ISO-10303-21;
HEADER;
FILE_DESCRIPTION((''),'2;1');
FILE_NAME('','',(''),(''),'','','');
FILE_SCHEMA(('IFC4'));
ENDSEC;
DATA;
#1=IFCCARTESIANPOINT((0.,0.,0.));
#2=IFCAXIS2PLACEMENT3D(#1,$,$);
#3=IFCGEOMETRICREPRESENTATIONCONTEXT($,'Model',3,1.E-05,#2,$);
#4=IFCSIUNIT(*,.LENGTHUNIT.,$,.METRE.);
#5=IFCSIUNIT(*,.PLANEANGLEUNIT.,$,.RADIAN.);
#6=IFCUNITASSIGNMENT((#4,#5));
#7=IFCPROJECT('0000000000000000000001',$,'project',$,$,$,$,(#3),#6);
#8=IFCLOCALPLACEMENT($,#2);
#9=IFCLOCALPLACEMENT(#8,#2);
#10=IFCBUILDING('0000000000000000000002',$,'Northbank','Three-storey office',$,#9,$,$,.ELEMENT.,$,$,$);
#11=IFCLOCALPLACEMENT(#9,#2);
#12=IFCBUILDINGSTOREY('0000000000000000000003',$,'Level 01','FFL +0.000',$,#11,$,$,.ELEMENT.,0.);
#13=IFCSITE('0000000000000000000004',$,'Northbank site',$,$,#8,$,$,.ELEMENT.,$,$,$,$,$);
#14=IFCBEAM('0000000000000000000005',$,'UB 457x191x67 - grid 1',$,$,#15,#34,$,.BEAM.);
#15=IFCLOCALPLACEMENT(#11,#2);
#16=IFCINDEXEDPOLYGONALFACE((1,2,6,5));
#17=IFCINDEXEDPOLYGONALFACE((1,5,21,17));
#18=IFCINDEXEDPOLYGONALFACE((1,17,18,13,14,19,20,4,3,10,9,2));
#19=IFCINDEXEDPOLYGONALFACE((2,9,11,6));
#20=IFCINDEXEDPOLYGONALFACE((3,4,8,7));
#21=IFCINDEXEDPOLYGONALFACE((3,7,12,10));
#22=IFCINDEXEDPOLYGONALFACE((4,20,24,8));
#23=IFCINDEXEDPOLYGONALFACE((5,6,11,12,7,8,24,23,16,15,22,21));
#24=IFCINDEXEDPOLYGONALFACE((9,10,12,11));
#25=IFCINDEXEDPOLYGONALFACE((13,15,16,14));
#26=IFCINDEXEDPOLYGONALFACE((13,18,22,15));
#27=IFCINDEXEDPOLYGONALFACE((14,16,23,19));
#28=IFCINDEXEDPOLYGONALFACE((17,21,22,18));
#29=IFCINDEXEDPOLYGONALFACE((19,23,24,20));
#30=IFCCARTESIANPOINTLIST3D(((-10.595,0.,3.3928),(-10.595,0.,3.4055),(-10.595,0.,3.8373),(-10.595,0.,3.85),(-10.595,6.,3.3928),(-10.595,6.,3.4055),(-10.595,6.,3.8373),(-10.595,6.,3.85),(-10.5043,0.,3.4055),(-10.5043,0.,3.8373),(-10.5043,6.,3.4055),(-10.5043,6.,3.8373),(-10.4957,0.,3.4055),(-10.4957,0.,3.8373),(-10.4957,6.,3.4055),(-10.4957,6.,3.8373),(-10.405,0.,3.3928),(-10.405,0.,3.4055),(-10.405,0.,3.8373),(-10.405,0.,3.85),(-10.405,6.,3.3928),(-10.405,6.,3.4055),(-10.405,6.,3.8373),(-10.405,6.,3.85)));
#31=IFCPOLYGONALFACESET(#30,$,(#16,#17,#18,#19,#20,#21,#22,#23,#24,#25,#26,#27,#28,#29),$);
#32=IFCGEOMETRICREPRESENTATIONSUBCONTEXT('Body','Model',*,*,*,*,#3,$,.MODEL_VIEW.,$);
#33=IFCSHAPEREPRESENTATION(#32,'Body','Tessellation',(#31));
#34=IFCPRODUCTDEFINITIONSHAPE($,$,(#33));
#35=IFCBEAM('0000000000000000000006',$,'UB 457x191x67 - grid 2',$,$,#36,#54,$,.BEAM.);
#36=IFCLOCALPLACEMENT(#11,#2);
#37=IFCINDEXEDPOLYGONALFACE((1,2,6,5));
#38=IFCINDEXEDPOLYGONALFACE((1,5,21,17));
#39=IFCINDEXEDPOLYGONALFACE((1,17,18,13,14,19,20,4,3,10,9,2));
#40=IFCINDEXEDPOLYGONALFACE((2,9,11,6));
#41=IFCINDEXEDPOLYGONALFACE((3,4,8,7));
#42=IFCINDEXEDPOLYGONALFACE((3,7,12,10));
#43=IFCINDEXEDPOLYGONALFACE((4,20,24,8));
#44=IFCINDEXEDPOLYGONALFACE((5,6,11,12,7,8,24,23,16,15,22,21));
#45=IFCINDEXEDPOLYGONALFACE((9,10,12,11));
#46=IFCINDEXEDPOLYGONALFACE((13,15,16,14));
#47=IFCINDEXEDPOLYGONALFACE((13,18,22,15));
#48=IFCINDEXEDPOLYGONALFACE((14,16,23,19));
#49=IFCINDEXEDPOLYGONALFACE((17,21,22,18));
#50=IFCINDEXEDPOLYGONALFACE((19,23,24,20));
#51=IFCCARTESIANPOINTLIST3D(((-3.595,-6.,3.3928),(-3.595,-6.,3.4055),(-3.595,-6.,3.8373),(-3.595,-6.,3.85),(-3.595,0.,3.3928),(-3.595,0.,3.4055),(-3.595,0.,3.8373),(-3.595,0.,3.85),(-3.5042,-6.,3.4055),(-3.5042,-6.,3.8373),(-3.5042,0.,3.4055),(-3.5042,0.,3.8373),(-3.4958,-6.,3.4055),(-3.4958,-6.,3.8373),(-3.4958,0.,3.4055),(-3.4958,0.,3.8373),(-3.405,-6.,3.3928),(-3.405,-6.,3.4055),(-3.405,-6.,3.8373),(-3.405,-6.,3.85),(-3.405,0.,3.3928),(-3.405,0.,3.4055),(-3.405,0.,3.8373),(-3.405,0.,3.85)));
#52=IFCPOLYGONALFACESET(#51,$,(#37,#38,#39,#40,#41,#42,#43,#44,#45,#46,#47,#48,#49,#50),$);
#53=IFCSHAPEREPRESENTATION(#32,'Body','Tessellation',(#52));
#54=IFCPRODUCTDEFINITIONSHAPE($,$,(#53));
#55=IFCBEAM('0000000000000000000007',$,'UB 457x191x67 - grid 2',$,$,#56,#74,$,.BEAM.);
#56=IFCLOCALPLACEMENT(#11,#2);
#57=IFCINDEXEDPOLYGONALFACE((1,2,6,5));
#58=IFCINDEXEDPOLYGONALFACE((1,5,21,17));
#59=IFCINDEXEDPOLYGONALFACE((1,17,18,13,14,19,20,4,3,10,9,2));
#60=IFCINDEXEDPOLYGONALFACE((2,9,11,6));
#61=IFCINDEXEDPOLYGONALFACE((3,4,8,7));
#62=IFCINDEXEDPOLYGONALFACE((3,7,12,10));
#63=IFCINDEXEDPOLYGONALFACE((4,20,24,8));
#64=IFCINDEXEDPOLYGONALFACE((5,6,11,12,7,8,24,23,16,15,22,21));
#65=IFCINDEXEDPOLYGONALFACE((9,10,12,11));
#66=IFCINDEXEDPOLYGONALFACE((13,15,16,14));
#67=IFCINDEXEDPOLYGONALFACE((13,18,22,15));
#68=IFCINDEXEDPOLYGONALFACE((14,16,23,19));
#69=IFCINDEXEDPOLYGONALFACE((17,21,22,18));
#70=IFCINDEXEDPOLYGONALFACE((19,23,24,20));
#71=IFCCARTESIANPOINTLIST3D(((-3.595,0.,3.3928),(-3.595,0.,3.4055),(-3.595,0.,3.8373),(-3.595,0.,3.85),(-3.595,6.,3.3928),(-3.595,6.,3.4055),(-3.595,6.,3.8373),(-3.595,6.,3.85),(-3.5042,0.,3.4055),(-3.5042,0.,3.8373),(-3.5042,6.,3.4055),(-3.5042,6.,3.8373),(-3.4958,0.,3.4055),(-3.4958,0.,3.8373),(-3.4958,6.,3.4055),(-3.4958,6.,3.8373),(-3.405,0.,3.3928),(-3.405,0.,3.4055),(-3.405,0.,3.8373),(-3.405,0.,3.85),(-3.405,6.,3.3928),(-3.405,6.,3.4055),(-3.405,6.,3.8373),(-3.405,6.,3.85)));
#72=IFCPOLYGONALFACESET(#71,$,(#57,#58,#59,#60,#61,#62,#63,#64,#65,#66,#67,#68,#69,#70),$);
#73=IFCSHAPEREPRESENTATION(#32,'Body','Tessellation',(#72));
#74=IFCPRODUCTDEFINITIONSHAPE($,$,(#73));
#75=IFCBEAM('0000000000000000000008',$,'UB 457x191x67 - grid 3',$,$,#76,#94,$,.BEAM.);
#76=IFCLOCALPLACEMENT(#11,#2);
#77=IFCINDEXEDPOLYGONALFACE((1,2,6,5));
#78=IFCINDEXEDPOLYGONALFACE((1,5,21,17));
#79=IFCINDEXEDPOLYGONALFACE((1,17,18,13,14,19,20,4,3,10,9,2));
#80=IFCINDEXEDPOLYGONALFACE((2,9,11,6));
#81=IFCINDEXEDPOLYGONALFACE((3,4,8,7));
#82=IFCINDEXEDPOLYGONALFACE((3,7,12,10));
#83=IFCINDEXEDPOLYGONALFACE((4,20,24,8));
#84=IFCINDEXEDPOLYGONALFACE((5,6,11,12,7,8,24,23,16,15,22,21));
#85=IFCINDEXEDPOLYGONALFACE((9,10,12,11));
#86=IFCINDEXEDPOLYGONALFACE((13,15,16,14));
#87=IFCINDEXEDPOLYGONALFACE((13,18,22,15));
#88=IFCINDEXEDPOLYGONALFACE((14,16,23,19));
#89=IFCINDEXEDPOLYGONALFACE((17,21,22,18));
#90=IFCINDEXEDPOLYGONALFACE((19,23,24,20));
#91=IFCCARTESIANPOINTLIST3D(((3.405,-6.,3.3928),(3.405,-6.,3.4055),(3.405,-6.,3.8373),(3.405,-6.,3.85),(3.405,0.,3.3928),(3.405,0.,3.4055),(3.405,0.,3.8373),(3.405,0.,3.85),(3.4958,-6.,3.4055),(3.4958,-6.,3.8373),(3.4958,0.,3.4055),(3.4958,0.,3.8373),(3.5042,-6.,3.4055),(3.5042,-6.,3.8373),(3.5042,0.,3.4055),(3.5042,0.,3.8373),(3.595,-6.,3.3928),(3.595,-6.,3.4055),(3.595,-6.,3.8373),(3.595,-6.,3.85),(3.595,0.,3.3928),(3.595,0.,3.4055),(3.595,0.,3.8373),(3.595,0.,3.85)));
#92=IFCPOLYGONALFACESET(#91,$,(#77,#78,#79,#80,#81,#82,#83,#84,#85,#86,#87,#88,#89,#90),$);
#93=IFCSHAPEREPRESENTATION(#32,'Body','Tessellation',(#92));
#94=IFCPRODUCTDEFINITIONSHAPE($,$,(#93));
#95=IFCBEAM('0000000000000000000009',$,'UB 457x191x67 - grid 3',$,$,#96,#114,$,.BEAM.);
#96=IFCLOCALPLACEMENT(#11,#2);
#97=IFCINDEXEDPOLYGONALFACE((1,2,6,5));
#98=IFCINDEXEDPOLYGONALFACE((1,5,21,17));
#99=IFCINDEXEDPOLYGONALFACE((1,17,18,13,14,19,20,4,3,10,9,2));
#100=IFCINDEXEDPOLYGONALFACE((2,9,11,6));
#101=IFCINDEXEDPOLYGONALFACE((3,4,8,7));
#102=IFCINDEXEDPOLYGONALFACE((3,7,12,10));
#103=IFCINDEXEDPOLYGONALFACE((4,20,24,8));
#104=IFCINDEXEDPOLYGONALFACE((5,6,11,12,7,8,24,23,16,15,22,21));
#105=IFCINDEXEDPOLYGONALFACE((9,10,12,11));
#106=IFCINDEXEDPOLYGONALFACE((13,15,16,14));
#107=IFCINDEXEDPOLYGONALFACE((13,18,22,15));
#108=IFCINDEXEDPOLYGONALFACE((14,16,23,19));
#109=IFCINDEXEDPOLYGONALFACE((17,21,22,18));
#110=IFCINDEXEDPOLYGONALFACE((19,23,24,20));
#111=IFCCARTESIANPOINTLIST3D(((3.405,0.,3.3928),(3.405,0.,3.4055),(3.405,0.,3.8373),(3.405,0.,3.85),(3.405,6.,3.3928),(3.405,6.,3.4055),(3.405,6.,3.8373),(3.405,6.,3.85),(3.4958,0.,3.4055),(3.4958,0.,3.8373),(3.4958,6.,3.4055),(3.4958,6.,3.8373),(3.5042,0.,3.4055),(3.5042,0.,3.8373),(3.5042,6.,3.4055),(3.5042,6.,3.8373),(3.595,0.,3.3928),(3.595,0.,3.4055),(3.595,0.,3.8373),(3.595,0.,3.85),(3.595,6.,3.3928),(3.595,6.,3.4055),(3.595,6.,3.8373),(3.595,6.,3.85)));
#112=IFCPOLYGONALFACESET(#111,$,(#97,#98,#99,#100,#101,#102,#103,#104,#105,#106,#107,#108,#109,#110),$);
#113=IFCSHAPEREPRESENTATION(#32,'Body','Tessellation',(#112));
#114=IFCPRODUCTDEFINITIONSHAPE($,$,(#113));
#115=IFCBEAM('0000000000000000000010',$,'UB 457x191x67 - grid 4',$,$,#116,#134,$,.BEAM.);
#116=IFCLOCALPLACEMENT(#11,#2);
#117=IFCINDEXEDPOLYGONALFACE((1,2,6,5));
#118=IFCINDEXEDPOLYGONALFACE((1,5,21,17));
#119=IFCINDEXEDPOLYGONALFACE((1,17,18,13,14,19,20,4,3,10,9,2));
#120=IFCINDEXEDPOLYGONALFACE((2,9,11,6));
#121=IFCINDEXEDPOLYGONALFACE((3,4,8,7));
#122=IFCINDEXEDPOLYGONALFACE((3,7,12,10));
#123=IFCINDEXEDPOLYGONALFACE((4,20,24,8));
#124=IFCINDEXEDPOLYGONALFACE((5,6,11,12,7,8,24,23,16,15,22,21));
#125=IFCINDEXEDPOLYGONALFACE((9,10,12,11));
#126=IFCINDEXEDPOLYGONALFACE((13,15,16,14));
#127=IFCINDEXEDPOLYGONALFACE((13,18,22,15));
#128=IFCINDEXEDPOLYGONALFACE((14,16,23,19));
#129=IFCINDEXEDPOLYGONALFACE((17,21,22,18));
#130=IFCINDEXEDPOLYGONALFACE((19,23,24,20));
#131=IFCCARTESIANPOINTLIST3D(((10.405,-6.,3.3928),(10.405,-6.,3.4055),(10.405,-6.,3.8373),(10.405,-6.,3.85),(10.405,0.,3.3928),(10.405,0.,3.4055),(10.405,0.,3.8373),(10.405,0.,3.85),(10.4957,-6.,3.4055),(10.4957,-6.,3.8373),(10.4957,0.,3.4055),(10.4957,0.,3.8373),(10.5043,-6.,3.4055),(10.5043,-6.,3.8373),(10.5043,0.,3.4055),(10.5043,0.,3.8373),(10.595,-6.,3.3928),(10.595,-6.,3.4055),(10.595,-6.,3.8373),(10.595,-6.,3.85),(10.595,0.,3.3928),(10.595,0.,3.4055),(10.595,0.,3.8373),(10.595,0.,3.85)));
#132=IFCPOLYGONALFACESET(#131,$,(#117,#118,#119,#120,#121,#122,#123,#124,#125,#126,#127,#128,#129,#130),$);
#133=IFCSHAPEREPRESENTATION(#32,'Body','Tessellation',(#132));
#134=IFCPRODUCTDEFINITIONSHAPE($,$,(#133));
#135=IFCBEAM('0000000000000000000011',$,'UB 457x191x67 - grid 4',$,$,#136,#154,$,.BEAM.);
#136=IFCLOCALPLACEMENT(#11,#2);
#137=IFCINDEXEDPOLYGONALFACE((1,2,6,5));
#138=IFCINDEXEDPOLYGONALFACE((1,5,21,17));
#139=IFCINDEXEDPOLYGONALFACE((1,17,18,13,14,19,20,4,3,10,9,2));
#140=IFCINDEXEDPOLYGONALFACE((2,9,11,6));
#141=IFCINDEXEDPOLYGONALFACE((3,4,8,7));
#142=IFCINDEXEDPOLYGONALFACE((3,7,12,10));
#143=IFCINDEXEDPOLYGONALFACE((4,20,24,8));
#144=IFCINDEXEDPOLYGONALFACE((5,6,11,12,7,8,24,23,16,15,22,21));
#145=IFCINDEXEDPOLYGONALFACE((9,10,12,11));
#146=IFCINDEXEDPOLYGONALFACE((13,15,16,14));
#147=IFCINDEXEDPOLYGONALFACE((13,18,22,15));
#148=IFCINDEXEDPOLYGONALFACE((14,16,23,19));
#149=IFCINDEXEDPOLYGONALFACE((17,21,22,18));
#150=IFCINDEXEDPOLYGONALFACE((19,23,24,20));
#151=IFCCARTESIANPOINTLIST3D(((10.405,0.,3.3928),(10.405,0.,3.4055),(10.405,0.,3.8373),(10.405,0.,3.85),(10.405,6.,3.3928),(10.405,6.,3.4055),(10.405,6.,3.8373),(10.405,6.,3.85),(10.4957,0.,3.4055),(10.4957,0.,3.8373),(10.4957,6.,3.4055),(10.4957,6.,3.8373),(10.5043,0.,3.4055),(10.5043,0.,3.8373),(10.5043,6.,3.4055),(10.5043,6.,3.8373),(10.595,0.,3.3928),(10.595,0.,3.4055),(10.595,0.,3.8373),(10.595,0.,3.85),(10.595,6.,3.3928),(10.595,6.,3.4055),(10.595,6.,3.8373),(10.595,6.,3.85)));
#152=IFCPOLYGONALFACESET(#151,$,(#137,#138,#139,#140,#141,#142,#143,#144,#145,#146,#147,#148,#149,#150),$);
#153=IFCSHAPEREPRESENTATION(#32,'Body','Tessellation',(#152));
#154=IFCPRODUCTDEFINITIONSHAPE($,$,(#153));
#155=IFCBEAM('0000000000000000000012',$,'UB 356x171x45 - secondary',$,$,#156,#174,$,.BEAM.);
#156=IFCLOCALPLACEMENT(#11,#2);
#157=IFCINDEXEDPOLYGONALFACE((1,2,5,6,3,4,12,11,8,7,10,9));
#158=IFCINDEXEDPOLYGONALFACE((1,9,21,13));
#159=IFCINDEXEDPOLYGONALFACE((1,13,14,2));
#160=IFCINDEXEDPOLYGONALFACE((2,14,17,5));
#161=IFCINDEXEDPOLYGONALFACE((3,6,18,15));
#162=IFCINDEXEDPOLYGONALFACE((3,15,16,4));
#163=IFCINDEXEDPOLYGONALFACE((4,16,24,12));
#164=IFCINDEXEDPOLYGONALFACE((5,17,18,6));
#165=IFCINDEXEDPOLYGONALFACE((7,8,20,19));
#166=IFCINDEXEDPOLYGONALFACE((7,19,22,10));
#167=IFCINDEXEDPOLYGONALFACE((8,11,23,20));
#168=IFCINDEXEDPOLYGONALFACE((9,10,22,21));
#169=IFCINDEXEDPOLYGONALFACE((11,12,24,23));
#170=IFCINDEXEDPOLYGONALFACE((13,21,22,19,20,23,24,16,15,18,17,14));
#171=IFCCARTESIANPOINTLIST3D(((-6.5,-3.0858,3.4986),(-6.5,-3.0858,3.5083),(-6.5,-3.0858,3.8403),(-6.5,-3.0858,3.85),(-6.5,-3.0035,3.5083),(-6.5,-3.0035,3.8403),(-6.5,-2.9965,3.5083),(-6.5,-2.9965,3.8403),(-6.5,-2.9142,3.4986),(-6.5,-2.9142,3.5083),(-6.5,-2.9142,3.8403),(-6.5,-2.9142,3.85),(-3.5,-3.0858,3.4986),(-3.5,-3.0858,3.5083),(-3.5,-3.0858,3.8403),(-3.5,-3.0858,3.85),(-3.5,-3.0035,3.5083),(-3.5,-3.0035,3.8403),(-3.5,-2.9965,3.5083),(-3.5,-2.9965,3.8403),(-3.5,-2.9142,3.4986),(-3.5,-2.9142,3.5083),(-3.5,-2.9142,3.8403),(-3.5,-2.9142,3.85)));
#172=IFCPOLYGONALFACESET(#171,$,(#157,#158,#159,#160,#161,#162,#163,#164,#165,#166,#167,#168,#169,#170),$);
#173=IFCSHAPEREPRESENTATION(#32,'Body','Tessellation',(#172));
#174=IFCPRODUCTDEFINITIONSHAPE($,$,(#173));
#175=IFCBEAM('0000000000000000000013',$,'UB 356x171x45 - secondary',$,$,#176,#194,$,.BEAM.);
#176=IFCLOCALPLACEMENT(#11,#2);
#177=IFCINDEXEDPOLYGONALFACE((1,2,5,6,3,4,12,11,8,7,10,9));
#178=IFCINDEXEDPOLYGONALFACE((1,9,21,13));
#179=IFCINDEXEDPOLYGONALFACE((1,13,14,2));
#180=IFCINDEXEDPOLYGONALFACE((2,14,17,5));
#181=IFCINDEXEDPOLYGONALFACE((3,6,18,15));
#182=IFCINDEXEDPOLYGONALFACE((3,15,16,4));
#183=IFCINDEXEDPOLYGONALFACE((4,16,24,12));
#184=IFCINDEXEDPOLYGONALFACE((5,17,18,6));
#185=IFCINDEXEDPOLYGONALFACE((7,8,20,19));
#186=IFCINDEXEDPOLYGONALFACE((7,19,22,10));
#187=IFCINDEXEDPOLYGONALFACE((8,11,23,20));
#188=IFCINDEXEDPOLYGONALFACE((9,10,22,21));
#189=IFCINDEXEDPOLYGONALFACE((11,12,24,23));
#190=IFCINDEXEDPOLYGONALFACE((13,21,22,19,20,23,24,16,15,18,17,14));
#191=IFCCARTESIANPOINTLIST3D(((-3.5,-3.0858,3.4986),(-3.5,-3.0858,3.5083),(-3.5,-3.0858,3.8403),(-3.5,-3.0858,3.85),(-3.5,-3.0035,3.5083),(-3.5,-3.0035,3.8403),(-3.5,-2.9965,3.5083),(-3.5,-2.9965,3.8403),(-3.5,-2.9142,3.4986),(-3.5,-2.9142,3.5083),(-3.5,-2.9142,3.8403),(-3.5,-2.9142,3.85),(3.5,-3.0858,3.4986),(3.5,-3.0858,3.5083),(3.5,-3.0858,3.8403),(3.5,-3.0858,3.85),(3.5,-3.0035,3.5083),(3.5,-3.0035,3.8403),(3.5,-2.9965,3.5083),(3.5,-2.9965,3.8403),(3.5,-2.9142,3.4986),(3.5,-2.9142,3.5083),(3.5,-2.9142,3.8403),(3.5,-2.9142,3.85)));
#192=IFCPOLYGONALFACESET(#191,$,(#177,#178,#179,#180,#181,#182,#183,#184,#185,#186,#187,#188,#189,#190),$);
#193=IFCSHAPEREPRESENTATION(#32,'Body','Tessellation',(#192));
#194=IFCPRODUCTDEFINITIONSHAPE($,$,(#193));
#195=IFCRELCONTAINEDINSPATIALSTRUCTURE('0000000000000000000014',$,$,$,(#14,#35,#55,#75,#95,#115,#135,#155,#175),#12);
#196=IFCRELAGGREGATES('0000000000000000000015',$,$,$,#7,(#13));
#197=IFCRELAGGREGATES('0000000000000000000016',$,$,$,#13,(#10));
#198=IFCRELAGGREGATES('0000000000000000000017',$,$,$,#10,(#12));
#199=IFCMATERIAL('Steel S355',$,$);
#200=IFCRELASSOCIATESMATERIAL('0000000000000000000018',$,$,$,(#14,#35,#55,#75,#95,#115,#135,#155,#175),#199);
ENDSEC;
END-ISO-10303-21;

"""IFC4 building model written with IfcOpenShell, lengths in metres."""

from ifc_helpers import new_model, si_unit, frame, origin, place, context, subcontext, project, spatial, i_section, extrude, material, element, save


model = new_model("IFC4")

# Units and contexts
model_context = context("Model", 3, precision=1e-05, world=origin())
body_context = subcontext(model_context, "Body", "Model", "MODEL_VIEW")
ifc_project = project(units=[si_unit("LENGTHUNIT", "METRE"), si_unit("PLANEANGLEUNIT", "RADIAN")], contexts=[model_context])

# Site, building, storey
site_placement = place(None, origin())
site = spatial("IfcSite", under=ifc_project, at=site_placement, Name="Northbank site", CompositionType="ELEMENT")
building_placement = place(site_placement, origin())
building = spatial("IfcBuilding", under=site, at=building_placement, Name="Northbank", Description="Three-storey office", CompositionType="ELEMENT")
storey_placement = place(building_placement, origin())
storey = spatial("IfcBuildingStorey", under=building, at=storey_placement, Name="Level 01", Description="FFL +0.000", CompositionType="ELEMENT", Elevation=0.0)

# Beams
ifc_material = material(Name="Steel S355")
beam_1_placement = place(storey_placement, origin())
element("IfcBeam", 1, at=beam_1_placement, inside=storey, material=ifc_material, Name="UB 457x191x67 - grid 1", PredefinedType="BEAM", context=body_context, shape_type="SweptSolid", body=[
    extrude(i_section(OverallWidth=0.1899, OverallDepth=0.4572, WebThickness=0.0085, FlangeThickness=0.0127), frame((-10.5, 0.0, 3.6214), z_axis=(0.0, 1.0, 0.0), x_axis=(-1.0, 0.0, 0.0)), (0.0, 0.0, 1.0), 6.0),
])
beam_2_placement = place(storey_placement, origin())
element("IfcBeam", 2, at=beam_2_placement, inside=storey, material=ifc_material, Name="UB 457x191x67 - grid 2", PredefinedType="BEAM", context=body_context, shape_type="SweptSolid", body=[
    extrude(i_section(OverallWidth=0.1899, OverallDepth=0.4572, WebThickness=0.0085, FlangeThickness=0.0127), frame((-3.5, -6.0, 3.6214), z_axis=(0.0, 1.0, 0.0), x_axis=(-1.0, 0.0, 0.0)), (0.0, 0.0, 1.0), 6.0),
])
beam_3_placement = place(storey_placement, origin())
element("IfcBeam", 3, at=beam_3_placement, inside=storey, material=ifc_material, Name="UB 457x191x67 - grid 2", PredefinedType="BEAM", context=body_context, shape_type="SweptSolid", body=[
    extrude(i_section(OverallWidth=0.1899, OverallDepth=0.4572, WebThickness=0.0085, FlangeThickness=0.0127), frame((-3.5, 0.0, 3.6214), z_axis=(0.0, 1.0, 0.0), x_axis=(-1.0, 0.0, 0.0)), (0.0, 0.0, 1.0), 6.0),
])
beam_4_placement = place(storey_placement, origin())
element("IfcBeam", 4, at=beam_4_placement, inside=storey, material=ifc_material, Name="UB 457x191x67 - grid 3", PredefinedType="BEAM", context=body_context, shape_type="SweptSolid", body=[
    extrude(i_section(OverallWidth=0.1899, OverallDepth=0.4572, WebThickness=0.0085, FlangeThickness=0.0127), frame((3.5, -6.0, 3.6214), z_axis=(0.0, 1.0, 0.0), x_axis=(-1.0, 0.0, 0.0)), (0.0, 0.0, 1.0), 6.0),
])
beam_5_placement = place(storey_placement, origin())
element("IfcBeam", 5, at=beam_5_placement, inside=storey, material=ifc_material, Name="UB 457x191x67 - grid 3", PredefinedType="BEAM", context=body_context, shape_type="SweptSolid", body=[
    extrude(i_section(OverallWidth=0.1899, OverallDepth=0.4572, WebThickness=0.0085, FlangeThickness=0.0127), frame((3.5, 0.0, 3.6214), z_axis=(0.0, 1.0, 0.0), x_axis=(-1.0, 0.0, 0.0)), (0.0, 0.0, 1.0), 6.0),
])
beam_6_placement = place(storey_placement, origin())
element("IfcBeam", 6, at=beam_6_placement, inside=storey, material=ifc_material, Name="UB 457x191x67 - grid 4", PredefinedType="BEAM", context=body_context, shape_type="SweptSolid", body=[
    extrude(i_section(OverallWidth=0.1899, OverallDepth=0.4572, WebThickness=0.0085, FlangeThickness=0.0127), frame((10.5, -6.0, 3.6214), z_axis=(0.0, 1.0, 0.0), x_axis=(-1.0, 0.0, 0.0)), (0.0, 0.0, 1.0), 6.0),
])
beam_7_placement = place(storey_placement, origin())
element("IfcBeam", 7, at=beam_7_placement, inside=storey, material=ifc_material, Name="UB 457x191x67 - grid 4", PredefinedType="BEAM", context=body_context, shape_type="SweptSolid", body=[
    extrude(i_section(OverallWidth=0.1899, OverallDepth=0.4572, WebThickness=0.0085, FlangeThickness=0.0127), frame((10.5, 0.0, 3.6214), z_axis=(0.0, 1.0, 0.0), x_axis=(-1.0, 0.0, 0.0)), (0.0, 0.0, 1.0), 6.0),
])
beam_8_placement = place(storey_placement, origin())
element("IfcBeam", 8, at=beam_8_placement, inside=storey, material=ifc_material, Name="UB 356x171x45 - secondary", PredefinedType="BEAM", context=body_context, shape_type="SweptSolid", body=[
    extrude(i_section(OverallWidth=0.1715, OverallDepth=0.3514, WebThickness=0.007, FlangeThickness=0.0097), frame((-6.5, -3.0, 3.6743), z_axis=(1.0, 0.0, 0.0), x_axis=(0.0, 1.0, 0.0)), (0.0, 0.0, 1.0), 3.0),
])
beam_9_placement = place(storey_placement, origin())
element("IfcBeam", 9, at=beam_9_placement, inside=storey, material=ifc_material, Name="UB 356x171x45 - secondary", PredefinedType="BEAM", context=body_context, shape_type="SweptSolid", body=[
    extrude(i_section(OverallWidth=0.1715, OverallDepth=0.3514, WebThickness=0.007, FlangeThickness=0.0097), frame((-3.5, -3.0, 3.6743), z_axis=(1.0, 0.0, 0.0), x_axis=(0.0, 1.0, 0.0)), (0.0, 0.0, 1.0), 7.0),
])

save(model, "model.ifc")
